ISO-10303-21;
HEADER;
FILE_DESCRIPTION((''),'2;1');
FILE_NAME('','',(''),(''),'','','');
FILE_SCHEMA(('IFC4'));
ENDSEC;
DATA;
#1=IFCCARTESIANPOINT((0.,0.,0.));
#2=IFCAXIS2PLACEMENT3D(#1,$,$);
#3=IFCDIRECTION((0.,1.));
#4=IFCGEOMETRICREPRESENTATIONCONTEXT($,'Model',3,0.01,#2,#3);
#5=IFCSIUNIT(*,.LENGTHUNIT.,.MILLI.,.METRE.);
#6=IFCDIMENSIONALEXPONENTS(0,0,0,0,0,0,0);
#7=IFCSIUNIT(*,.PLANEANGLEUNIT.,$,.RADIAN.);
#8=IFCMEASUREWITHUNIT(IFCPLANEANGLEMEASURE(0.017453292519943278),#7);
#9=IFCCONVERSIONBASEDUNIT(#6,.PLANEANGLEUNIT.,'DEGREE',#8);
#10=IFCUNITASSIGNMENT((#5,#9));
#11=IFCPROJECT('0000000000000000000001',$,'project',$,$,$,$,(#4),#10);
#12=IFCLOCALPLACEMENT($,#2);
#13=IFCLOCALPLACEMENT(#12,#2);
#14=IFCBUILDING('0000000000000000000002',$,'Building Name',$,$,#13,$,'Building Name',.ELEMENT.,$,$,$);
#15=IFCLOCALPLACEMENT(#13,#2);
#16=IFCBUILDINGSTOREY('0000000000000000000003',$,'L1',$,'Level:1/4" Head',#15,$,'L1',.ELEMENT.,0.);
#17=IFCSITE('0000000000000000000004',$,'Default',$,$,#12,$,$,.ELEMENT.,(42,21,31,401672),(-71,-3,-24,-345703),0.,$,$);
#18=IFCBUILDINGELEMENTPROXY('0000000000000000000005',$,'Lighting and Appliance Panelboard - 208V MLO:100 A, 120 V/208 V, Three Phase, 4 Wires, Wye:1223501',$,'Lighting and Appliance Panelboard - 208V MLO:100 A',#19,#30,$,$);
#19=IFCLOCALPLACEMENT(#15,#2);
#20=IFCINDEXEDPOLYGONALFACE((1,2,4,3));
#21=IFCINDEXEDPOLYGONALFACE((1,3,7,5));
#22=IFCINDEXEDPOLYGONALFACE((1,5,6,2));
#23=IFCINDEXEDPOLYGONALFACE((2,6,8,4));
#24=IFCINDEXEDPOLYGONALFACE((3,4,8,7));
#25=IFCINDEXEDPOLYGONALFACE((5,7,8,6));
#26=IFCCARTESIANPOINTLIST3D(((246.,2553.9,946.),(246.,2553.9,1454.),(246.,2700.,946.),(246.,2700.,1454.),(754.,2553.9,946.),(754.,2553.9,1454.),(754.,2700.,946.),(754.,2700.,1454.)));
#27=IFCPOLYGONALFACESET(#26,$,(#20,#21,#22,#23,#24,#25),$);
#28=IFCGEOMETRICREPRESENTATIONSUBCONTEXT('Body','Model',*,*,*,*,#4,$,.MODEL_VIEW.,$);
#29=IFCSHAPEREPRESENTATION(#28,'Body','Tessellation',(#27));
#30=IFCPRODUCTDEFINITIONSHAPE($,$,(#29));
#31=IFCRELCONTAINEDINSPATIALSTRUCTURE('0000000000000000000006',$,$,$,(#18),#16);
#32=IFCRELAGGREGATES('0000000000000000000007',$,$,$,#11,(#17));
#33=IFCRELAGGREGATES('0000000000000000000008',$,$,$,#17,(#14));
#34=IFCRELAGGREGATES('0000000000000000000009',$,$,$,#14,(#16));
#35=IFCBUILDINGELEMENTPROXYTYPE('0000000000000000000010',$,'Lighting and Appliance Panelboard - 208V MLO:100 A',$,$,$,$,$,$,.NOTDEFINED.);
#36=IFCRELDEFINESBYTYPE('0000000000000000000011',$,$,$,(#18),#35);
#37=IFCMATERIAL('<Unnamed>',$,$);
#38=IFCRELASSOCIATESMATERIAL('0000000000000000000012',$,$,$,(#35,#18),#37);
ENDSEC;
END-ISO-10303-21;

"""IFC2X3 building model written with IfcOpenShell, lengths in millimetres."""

from ifc_helpers import new_model, entity, si_unit, converted_unit, direction, frame, origin, origin_2d_with_axis, place, context, subcontext, project, spatial, rectangle, extrude, source, transform, mapped, material, type_object, type_shapes, element, save


model = new_model("IFC2X3")

# Units and contexts
model_context = context("Model", 3, precision=0.01, world=origin(), true_north=direction((0.0, 1.0)))
body_context = subcontext(model_context, "Body", "Model", "MODEL_VIEW")
ifc_project = project(units=[si_unit("LENGTHUNIT", "METRE", prefix="MILLI"), converted_unit("PLANEANGLEUNIT", "DEGREE", entity("IfcPlaneAngleMeasure", 0.017453292519943278), si_unit("PLANEANGLEUNIT", "RADIAN"), dimensions=[0, 0, 0, 0, 0, 0, 0])], contexts=[model_context])

# Site, building, storey
site_placement = place(None, origin())
site = spatial("IfcSite", under=ifc_project, at=site_placement, Name="Default", CompositionType="ELEMENT", RefLatitude=(42, 21, 31, 401672), RefLongitude=(-71, -3, -24, -345703), RefElevation=0.0)
building_placement = place(site_placement, origin())
building = spatial("IfcBuilding", under=site, at=building_placement, Name="Building Name", LongName="Building Name", CompositionType="ELEMENT")
storey_placement = place(building_placement, origin())
storey = spatial("IfcBuildingStorey", under=building, at=storey_placement, Name="L1", ObjectType="Level:1/4\" Head", LongName="L1", CompositionType="ELEMENT", Elevation=0.0)

# Building element proxy
ifc_material = material(Name="<Unnamed>")
building_element_proxy_type_1 = type_object("IfcBuildingElementProxyType", Name="Lighting and Appliance Panelboard - 208V MLO:100 A", PredefinedType="NOTDEFINED", material=ifc_material)
shared_shape_1 = source(origin(), body_context, "Body", "SweptSolid", [
    extrude(rectangle(XDim=508.0, YDim=508.0, at=origin_2d_with_axis()), frame((0.0, 0.0, -146.1), z_axis=(0.0, 0.0, 1.0), x_axis=(-1.0, 0.0, 0.0)), (0.0, 0.0, 1.0), 146.1),
])
type_shapes(building_element_proxy_type_1, [shared_shape_1])
proxy_placement = place(storey_placement, frame((500.0, 2700.0, 1200.0), z_axis=(0.0, 1.0, 0.0), x_axis=(-1.0, 0.0, 0.0)))
element("IfcBuildingElementProxy", 1, at=proxy_placement, inside=storey, type_object=building_element_proxy_type_1, material=ifc_material, Name="Lighting and Appliance Panelboard - 208V MLO:100 A, 120 V/208 V, Three Phase, 4 Wires, Wye:1223501", ObjectType="Lighting and Appliance Panelboard - 208V MLO:100 A", context=body_context, shape_type="MappedRepresentation", body=[
    mapped(shared_shape_1, transform((0.0, 0.0, 0.0), scale=1.0)),
])

save(model, "model.ifc")
